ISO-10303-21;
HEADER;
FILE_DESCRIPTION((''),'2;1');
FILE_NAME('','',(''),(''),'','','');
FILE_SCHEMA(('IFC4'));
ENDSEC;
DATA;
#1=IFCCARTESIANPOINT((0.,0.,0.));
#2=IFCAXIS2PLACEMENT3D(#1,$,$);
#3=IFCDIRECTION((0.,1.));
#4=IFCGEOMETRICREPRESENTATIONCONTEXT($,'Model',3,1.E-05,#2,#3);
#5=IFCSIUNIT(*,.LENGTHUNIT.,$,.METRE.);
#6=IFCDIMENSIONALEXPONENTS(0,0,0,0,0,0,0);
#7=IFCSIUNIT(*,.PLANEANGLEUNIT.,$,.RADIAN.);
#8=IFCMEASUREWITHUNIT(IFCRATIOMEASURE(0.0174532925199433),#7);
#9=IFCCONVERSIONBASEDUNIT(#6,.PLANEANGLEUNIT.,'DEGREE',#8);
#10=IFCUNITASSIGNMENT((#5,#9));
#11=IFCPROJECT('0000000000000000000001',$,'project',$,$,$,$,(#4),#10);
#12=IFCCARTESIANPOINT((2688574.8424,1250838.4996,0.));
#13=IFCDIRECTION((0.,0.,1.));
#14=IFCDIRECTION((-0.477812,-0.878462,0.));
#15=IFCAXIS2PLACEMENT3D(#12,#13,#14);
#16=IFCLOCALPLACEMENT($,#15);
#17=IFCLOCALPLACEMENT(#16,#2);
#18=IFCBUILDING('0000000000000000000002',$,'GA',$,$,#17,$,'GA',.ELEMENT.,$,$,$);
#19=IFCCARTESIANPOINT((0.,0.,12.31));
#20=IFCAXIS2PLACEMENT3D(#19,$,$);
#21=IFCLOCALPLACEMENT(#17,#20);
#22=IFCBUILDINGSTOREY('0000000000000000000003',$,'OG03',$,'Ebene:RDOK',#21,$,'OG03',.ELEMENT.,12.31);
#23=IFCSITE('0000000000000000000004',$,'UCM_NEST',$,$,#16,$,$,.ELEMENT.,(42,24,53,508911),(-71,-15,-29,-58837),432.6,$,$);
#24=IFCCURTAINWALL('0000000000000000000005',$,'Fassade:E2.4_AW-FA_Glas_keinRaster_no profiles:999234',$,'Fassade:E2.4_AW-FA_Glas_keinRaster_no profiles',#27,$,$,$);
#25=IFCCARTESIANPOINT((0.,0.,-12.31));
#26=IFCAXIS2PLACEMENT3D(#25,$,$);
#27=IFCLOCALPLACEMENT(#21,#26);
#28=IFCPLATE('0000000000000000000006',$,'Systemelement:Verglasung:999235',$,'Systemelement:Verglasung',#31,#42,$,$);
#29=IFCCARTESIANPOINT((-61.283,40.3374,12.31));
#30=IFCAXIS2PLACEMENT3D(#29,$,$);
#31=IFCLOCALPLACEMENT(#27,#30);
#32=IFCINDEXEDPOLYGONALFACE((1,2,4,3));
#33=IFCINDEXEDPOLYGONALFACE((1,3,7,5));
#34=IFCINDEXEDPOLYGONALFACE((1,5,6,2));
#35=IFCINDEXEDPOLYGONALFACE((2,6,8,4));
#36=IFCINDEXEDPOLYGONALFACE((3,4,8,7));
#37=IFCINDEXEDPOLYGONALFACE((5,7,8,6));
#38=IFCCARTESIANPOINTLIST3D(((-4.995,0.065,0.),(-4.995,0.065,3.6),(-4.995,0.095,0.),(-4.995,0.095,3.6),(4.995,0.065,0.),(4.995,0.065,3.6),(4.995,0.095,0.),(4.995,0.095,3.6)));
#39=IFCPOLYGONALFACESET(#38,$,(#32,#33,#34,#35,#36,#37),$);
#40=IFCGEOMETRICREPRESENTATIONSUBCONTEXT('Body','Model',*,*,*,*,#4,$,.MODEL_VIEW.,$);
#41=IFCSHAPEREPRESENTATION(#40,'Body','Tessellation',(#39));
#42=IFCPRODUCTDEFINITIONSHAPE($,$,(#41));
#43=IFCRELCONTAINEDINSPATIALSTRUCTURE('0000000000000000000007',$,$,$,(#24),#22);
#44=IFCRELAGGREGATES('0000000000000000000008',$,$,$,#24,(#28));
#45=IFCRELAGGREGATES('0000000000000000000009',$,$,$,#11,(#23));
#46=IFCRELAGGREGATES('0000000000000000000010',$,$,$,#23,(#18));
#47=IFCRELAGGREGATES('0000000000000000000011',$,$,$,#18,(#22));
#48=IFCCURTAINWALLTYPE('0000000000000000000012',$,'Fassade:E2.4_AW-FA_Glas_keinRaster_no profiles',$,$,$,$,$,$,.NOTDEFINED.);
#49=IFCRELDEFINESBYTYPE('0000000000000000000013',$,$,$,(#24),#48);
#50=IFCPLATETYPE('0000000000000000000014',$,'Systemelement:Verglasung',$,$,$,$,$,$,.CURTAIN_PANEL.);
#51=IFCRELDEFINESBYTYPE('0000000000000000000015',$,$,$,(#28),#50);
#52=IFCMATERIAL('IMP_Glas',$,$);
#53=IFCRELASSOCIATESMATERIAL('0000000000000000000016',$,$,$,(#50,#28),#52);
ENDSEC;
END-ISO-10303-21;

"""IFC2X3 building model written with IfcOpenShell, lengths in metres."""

from ifc_helpers import new_model, entity, si_unit, converted_unit, direction, frame, frame_2d, origin, place, context, subcontext, project, spatial, rectangle, extrude, source, transform, mapped, material, type_object, type_shapes, element, aggregate, save


model = new_model("IFC2X3")

# Units and contexts
model_context = context("Model", 3, precision=1e-05, world=origin(), true_north=direction((0.0, 1.0)))
body_context = subcontext(model_context, "Body", "Model", "MODEL_VIEW")
ifc_project = project(units=[si_unit("LENGTHUNIT", "METRE"), converted_unit("PLANEANGLEUNIT", "DEGREE", entity("IfcRatioMeasure", 0.0174532925199433), si_unit("PLANEANGLEUNIT", "RADIAN"), dimensions=[0, 0, 0, 0, 0, 0, 0])], contexts=[model_context])

# Site, building, storey
site_placement = place(None, frame((2688574.8424, 1250838.4996, 0.0), z_axis=(0.0, 0.0, 1.0), x_axis=(-0.477812, -0.878462, 0.0)))
site = spatial("IfcSite", under=ifc_project, at=site_placement, Name="UCM_NEST", CompositionType="ELEMENT", RefLatitude=(42, 24, 53, 508911), RefLongitude=(-71, -15, -29, -58837), RefElevation=432.6)
building_placement = place(site_placement, origin())
building = spatial("IfcBuilding", under=site, at=building_placement, Name="GA", LongName="GA", CompositionType="ELEMENT")
storey_placement = place(building_placement, frame((0.0, 0.0, 12.31)))
storey = spatial("IfcBuildingStorey", under=building, at=storey_placement, Name="OG03", ObjectType="Ebene:RDOK", LongName="OG03", CompositionType="ELEMENT", Elevation=12.31)

# Curtain wall, plate
curtain_wall_type = type_object("IfcCurtainWallType", Name="Fassade:E2.4_AW-FA_Glas_keinRaster_no profiles", PredefinedType="NOTDEFINED")
curtain_wall_placement = place(storey_placement, frame((0.0, 0.0, -12.31)))
curtain_wall = element("IfcCurtainWall", 1, at=curtain_wall_placement, inside=storey, type_object=curtain_wall_type, Name="Fassade:E2.4_AW-FA_Glas_keinRaster_no profiles:999234", ObjectType="Fassade:E2.4_AW-FA_Glas_keinRaster_no profiles")
ifc_material_1 = material(Name="IMP_Glas")
plate_type = type_object("IfcPlateType", Name="Systemelement:Verglasung", PredefinedType="CURTAIN_PANEL", material=ifc_material_1)
shared_shape_1 = source(origin(), body_context, "Body", "SweptSolid", [
    extrude(rectangle(XDim=0.03, YDim=9.99, at=frame_2d((0.0, 0.0), x_axis=(1.0, 0.0))), frame((0.0, 0.08, 0.0), z_axis=(0.0, 0.0, 1.0), x_axis=(0.0, 1.0, 0.0)), (0.0, 0.0, 1.0), 3.6),
])
type_shapes(plate_type, [shared_shape_1])
plate_placement = place(curtain_wall_placement, frame((-61.283, 40.3374, 12.31)))
plate = element("IfcPlate", 2, at=plate_placement, type_object=plate_type, material=ifc_material_1, Name="Systemelement:Verglasung:999235", ObjectType="Systemelement:Verglasung", context=body_context, shape_type="MappedRepresentation", body=[
    mapped(shared_shape_1, transform((0.0, 0.0, 0.0), scale=1.0)),
])
aggregate(curtain_wall, [plate])

save(model, "model.ifc")
